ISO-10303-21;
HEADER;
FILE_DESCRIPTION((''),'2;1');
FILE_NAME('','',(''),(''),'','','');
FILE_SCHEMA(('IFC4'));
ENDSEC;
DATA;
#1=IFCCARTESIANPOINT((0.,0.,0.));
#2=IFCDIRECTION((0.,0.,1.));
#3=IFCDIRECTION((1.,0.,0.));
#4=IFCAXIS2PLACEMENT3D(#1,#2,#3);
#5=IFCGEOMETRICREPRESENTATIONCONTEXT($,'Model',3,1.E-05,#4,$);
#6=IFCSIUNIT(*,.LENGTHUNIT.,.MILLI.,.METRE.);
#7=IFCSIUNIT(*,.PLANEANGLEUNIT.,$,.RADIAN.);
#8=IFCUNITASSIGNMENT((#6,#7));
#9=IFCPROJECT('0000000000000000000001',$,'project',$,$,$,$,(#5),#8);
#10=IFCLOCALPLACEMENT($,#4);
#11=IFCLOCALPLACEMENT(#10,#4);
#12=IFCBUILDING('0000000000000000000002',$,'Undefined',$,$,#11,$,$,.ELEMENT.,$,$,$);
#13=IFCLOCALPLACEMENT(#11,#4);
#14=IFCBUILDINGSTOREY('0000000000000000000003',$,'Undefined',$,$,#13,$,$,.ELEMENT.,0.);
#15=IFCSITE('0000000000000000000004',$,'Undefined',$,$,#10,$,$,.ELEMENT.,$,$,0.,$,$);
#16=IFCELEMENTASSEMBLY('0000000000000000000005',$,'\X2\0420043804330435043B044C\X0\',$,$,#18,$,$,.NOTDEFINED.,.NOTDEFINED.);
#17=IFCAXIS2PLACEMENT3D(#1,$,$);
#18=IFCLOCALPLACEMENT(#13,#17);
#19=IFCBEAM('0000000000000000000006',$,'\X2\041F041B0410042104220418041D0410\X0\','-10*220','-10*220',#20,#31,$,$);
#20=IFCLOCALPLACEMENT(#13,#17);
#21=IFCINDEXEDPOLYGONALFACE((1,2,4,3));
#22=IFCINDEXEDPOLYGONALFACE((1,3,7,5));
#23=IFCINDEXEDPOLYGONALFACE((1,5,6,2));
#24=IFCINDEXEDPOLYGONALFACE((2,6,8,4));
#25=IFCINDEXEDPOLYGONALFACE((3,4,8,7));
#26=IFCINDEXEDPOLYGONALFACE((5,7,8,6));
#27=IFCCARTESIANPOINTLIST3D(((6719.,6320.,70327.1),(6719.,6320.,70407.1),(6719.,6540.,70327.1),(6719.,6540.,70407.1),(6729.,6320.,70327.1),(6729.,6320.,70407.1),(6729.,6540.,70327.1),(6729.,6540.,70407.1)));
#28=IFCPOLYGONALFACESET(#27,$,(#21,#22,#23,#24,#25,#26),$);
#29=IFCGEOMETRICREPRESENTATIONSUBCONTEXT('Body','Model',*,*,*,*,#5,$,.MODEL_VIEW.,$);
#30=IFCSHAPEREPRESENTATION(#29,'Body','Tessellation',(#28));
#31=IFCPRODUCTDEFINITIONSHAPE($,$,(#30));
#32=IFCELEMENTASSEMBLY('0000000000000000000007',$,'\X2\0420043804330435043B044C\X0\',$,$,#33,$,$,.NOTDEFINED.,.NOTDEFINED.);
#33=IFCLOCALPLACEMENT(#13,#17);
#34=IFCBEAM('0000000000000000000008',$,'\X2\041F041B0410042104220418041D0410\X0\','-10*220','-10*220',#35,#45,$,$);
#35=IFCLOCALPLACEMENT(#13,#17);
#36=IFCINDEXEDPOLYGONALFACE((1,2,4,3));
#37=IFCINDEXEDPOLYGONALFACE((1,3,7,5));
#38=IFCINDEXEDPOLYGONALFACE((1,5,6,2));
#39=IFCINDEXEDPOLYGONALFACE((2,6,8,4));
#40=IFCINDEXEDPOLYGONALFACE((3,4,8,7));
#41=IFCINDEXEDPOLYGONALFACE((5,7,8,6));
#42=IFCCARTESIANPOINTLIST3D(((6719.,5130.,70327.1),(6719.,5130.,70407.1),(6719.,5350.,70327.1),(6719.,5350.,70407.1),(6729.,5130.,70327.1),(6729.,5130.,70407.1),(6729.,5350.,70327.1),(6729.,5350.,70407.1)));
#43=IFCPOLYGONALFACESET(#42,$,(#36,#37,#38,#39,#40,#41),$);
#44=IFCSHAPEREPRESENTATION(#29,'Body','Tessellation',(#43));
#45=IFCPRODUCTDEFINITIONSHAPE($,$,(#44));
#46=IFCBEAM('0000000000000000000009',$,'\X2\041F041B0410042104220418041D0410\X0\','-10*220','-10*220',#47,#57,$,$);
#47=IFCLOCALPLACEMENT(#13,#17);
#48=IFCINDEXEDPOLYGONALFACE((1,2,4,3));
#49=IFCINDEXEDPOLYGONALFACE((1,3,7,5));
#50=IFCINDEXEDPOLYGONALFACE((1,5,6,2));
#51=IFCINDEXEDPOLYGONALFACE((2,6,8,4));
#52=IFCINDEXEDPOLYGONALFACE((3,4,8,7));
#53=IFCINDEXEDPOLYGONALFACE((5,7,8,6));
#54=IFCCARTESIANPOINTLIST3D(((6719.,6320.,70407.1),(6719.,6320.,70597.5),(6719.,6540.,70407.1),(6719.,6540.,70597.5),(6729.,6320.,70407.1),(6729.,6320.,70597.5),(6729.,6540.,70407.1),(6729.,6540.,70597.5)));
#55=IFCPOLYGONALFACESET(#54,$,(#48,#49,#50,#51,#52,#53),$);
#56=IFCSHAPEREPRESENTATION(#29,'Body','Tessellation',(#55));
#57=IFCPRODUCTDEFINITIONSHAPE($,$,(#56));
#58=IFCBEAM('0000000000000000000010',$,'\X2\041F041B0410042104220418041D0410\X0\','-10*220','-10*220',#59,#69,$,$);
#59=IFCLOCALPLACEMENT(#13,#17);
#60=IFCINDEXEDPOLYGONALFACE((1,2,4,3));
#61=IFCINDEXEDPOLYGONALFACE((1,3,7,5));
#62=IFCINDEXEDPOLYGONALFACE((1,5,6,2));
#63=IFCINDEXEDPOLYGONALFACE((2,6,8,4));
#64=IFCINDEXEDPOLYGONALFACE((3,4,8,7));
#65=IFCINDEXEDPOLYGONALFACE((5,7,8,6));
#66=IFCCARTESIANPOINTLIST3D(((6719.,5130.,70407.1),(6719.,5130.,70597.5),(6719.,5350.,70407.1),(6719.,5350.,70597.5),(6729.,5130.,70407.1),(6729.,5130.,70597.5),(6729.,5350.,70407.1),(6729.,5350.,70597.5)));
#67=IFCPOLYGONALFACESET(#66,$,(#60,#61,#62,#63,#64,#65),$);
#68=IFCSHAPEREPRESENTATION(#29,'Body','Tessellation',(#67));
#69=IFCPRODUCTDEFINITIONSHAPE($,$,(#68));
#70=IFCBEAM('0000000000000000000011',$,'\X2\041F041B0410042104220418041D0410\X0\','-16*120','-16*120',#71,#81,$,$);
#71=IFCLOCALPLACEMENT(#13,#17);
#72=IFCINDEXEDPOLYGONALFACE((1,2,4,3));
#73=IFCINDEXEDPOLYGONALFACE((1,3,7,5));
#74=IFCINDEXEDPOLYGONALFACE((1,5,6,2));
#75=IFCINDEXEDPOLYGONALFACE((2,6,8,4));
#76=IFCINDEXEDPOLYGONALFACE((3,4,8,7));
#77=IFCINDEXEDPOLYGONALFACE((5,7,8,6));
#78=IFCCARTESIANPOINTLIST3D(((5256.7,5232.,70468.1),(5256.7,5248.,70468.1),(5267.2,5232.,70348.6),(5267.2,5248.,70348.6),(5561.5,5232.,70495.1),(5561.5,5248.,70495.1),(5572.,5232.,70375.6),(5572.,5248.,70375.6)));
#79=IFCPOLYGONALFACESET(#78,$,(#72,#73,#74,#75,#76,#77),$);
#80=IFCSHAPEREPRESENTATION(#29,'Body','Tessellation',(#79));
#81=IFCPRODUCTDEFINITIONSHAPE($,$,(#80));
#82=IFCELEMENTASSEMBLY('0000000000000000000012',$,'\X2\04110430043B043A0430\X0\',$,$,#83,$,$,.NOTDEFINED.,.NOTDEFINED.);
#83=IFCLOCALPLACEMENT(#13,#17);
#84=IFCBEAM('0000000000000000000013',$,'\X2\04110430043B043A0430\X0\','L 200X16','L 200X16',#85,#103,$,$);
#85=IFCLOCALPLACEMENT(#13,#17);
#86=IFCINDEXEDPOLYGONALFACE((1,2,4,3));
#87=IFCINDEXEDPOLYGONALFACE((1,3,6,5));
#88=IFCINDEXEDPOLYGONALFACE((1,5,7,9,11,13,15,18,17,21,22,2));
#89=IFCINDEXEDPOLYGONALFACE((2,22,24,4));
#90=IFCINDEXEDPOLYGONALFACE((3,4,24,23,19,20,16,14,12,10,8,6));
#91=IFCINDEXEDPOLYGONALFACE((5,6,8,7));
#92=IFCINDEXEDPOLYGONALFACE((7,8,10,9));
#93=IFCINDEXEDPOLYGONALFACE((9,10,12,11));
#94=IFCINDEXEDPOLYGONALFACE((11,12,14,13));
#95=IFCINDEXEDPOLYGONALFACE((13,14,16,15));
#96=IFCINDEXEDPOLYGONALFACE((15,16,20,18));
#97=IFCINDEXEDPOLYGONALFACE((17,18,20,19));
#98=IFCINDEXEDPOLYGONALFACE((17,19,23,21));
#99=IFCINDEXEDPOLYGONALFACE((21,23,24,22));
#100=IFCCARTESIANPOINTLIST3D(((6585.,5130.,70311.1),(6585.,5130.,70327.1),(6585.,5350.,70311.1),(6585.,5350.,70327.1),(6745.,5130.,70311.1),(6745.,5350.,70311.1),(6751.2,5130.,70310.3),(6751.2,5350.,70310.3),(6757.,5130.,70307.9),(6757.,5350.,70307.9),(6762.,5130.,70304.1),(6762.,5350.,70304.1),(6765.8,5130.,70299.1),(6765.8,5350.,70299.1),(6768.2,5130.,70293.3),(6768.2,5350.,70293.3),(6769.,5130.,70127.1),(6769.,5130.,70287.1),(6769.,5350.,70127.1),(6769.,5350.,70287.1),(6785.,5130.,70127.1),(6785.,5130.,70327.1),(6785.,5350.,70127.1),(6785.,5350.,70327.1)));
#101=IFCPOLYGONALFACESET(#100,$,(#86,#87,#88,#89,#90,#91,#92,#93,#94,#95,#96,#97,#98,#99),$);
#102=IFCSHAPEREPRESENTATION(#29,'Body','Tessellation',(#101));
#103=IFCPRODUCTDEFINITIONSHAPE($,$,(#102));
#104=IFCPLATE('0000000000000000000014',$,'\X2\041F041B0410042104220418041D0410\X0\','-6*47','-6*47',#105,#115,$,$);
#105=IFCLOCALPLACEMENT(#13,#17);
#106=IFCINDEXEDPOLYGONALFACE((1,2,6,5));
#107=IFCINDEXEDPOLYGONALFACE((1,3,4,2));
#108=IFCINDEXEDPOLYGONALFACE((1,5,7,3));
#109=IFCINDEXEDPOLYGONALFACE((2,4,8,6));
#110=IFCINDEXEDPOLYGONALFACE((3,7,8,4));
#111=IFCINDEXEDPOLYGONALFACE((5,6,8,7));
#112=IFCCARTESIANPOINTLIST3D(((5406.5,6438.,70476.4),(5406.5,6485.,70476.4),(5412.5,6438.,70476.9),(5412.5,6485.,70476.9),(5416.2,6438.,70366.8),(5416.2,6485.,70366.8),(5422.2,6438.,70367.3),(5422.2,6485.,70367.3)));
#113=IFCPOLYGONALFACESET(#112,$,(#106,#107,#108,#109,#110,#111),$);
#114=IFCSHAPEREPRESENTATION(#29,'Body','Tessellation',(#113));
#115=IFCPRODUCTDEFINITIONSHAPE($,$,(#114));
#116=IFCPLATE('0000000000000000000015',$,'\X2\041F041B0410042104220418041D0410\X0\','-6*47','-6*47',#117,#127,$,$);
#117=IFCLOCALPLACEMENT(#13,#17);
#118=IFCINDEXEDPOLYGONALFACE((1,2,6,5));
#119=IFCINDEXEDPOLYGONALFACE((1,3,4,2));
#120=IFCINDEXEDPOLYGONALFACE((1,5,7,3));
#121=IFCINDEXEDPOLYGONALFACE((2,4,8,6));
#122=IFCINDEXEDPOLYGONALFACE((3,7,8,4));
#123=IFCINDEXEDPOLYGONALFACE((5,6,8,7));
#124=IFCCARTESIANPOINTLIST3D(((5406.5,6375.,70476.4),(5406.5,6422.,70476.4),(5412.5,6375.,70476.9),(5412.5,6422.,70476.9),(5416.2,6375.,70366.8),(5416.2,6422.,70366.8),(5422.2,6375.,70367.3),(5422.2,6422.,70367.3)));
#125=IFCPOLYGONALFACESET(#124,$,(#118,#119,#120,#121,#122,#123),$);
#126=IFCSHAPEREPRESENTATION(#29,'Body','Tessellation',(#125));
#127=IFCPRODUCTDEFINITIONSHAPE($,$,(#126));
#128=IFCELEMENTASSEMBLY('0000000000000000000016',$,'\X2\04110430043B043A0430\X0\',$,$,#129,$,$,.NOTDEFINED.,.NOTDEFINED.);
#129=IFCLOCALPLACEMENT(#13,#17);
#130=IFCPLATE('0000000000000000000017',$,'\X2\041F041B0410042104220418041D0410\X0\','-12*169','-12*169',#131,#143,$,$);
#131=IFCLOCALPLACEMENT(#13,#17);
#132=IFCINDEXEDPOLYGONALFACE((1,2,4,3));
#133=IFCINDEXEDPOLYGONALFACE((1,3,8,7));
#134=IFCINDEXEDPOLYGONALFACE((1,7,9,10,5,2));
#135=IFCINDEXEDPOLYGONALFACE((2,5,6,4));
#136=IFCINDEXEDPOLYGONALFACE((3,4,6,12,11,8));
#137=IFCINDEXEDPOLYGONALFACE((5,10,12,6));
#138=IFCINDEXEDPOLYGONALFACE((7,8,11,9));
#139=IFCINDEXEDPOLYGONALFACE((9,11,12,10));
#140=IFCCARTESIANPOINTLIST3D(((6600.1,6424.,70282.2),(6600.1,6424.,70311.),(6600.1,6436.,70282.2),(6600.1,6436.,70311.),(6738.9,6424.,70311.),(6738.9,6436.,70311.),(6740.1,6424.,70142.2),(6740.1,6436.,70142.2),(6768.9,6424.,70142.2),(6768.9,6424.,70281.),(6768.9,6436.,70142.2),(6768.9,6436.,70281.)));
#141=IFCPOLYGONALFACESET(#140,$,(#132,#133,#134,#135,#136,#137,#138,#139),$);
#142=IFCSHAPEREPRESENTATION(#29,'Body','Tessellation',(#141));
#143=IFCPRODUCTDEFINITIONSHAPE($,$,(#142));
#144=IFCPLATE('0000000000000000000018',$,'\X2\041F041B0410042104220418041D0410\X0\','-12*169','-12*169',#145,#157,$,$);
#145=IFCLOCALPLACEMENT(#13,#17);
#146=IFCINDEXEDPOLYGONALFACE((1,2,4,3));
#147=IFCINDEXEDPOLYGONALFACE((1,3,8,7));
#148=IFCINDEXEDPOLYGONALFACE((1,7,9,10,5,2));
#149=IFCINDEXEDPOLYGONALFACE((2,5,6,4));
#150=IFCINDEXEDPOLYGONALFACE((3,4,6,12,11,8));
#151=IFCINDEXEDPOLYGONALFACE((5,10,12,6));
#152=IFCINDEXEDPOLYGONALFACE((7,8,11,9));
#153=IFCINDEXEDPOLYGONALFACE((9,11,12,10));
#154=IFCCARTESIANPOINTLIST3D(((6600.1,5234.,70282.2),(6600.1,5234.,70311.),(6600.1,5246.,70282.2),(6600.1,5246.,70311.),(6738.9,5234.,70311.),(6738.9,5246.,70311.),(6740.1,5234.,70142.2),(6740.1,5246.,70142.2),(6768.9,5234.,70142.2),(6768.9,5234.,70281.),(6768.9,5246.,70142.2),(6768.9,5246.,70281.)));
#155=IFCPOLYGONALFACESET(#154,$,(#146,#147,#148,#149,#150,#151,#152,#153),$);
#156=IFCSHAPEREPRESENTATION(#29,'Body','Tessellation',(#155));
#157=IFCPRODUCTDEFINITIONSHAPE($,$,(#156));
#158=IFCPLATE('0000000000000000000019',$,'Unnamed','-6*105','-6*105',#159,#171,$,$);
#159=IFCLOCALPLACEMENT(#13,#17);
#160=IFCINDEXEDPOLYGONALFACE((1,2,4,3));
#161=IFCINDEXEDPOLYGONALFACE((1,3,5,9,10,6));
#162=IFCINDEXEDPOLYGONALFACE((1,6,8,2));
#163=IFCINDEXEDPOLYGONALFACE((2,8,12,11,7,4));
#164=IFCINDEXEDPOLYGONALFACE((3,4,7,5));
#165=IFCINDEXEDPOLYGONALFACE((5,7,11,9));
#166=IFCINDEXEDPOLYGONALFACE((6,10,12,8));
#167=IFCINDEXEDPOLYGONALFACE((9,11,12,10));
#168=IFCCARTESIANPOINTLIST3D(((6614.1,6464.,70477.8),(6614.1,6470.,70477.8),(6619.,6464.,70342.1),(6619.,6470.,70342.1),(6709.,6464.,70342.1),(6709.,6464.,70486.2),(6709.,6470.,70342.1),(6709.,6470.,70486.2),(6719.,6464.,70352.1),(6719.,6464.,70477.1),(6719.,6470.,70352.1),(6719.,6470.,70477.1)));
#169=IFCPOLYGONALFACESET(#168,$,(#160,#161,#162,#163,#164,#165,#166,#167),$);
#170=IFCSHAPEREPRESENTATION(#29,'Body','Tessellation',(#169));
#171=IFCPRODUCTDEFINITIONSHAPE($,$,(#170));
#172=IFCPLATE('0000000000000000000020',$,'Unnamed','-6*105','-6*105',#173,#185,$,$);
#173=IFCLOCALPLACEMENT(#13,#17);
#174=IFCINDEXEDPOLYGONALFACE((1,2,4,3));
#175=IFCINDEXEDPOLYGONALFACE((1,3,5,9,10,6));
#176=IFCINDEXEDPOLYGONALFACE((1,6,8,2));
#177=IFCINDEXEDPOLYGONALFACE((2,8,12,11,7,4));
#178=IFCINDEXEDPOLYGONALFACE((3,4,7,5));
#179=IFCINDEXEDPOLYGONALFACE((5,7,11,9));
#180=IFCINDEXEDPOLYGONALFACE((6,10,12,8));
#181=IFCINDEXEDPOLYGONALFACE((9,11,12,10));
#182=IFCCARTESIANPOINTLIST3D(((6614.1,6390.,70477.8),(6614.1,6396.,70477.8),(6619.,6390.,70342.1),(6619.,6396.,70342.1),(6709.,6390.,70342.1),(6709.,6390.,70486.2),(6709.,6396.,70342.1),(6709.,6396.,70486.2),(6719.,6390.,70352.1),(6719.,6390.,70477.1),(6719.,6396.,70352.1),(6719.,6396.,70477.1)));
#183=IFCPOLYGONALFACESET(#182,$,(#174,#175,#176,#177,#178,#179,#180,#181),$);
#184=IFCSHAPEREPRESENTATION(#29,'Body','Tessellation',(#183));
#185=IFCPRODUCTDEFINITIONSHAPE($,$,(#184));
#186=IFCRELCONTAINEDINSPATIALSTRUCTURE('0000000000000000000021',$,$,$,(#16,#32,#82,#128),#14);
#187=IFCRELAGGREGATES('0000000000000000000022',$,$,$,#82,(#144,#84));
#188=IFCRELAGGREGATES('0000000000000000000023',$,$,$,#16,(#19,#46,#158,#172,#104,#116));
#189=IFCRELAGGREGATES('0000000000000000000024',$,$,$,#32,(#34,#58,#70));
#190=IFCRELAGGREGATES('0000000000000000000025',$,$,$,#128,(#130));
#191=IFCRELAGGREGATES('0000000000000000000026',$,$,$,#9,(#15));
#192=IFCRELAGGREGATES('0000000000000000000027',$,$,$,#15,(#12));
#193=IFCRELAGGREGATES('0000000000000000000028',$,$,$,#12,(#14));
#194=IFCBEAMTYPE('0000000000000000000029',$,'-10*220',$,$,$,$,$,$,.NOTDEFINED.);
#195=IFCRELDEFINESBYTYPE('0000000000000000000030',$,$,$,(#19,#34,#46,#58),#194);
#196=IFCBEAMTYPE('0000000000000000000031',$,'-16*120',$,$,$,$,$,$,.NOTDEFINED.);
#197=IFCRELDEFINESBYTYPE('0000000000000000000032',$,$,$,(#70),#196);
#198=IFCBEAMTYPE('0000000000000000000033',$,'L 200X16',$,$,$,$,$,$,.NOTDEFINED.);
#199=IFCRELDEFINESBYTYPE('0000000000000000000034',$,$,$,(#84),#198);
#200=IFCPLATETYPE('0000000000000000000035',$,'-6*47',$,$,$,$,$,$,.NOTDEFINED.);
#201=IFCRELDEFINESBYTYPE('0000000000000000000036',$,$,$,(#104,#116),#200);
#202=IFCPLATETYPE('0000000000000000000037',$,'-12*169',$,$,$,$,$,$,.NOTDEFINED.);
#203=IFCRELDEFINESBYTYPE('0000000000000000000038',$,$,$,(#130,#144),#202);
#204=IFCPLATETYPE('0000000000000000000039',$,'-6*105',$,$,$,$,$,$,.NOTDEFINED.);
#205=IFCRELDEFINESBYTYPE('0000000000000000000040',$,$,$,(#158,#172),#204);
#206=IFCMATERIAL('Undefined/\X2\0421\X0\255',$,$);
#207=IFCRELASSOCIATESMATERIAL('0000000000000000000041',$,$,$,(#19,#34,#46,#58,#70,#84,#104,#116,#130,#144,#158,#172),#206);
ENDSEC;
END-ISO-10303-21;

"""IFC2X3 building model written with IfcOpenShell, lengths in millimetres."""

from ifc_helpers import new_model, si_unit, frame, origin_with_axes, origin_2d_with_axis, place, context, subcontext, project, spatial, polyline, rectangle, l_section, outline, extrude, boolean, material, type_object, element, aggregate, save


model = new_model("IFC2X3")

# Units and contexts
model_context = context("Model", 3, precision=1e-05, world=origin_with_axes())
body_context = subcontext(model_context, "Body", "Model", "MODEL_VIEW")
ifc_project = project(units=[si_unit("LENGTHUNIT", "METRE", prefix="MILLI"), si_unit("PLANEANGLEUNIT", "RADIAN")], contexts=[model_context])

# Site, building, storey
site_placement = place(None, origin_with_axes())
site = spatial("IfcSite", under=ifc_project, at=site_placement, Name="Undefined", CompositionType="ELEMENT", RefElevation=0.0)
building_placement = place(site_placement, origin_with_axes())
building = spatial("IfcBuilding", under=site, at=building_placement, Name="Undefined", CompositionType="ELEMENT")
storey_placement = place(building_placement, origin_with_axes())
storey = spatial("IfcBuildingStorey", under=building, at=storey_placement, Name="Undefined", CompositionType="ELEMENT", Elevation=0.0)

# Element assemblies, beams
assembly_1_placement = place(storey_placement, origin_with_axes())
assembly_1 = element("IfcElementAssembly", 1, at=assembly_1_placement, inside=storey, Name="Ригель", AssemblyPlace="NOTDEFINED", PredefinedType="NOTDEFINED")
ifc_material_1 = material(Name="Undefined/С255")
beam_type_1 = type_object("IfcBeamType", Name="-10*220", PredefinedType="NOTDEFINED")
beam_1_placement = place(assembly_1_placement, frame((6724.0, 6430.0, 70327.1), z_axis=(0.0, 1.0, 0.0), x_axis=(0.0, 0.0, 1.0)))
beam_1 = element("IfcBeam", 2, at=beam_1_placement, type_object=beam_type_1, material=ifc_material_1, Name="ПЛАСТИНА", Description="-10*220", ObjectType="-10*220", context=body_context, shape_type="SweptSolid", body=[
    extrude(rectangle(XDim=10.0, YDim=220.0, at=origin_2d_with_axis()), frame((80.0, 0.0, 0.0), z_axis=(-1.0, 0.0, 0.0), x_axis=(0.0, -1.0, 0.0)), (0.0, 0.0, 1.0), 80.0),
])
assembly_2_placement = place(storey_placement, origin_with_axes())
assembly_2 = element("IfcElementAssembly", 3, at=assembly_2_placement, inside=storey, Name="Ригель", AssemblyPlace="NOTDEFINED", PredefinedType="NOTDEFINED")
beam_2_placement = place(assembly_2_placement, frame((6724.0, 5240.0, 70327.1), z_axis=(0.0, 1.0, 0.0), x_axis=(0.0, 0.0, 1.0)))
beam_2 = element("IfcBeam", 4, at=beam_2_placement, type_object=beam_type_1, material=ifc_material_1, Name="ПЛАСТИНА", Description="-10*220", ObjectType="-10*220", context=body_context, shape_type="SweptSolid", body=[
    extrude(rectangle(XDim=10.0, YDim=220.0, at=origin_2d_with_axis()), frame((80.0, 0.0, 0.0), z_axis=(-1.0, 0.0, 0.0), x_axis=(0.0, -1.0, 0.0)), (0.0, 0.0, 1.0), 80.0),
])

# Beams
beam_3_placement = place(assembly_1_placement, frame((6724.0, 6430.0, 70407.1), z_axis=(0.0, 1.0, 0.0), x_axis=(0.0, 0.0, 1.0)))
beam_3 = element("IfcBeam", 5, at=beam_3_placement, type_object=beam_type_1, material=ifc_material_1, Name="ПЛАСТИНА", Description="-10*220", ObjectType="-10*220", context=body_context, shape_type="SweptSolid", body=[
    extrude(rectangle(XDim=10.0, YDim=220.0, at=origin_2d_with_axis()), frame((190.4, 0.0, 0.0), z_axis=(-1.0, 0.0, 0.0), x_axis=(0.0, -1.0, 0.0)), (0.0, 0.0, 1.0), 190.4),
])
beam_4_placement = place(assembly_2_placement, frame((6724.0, 5240.0, 70407.1), z_axis=(0.0, 1.0, 0.0), x_axis=(0.0, 0.0, 1.0)))
beam_4 = element("IfcBeam", 6, at=beam_4_placement, type_object=beam_type_1, material=ifc_material_1, Name="ПЛАСТИНА", Description="-10*220", ObjectType="-10*220", context=body_context, shape_type="SweptSolid", body=[
    extrude(rectangle(XDim=10.0, YDim=220.0, at=origin_2d_with_axis()), frame((190.4, 0.0, 0.0), z_axis=(-1.0, 0.0, 0.0), x_axis=(0.0, -1.0, 0.0)), (0.0, 0.0, 1.0), 190.4),
])
beam_type_2 = type_object("IfcBeamType", Name="-16*120", PredefinedType="NOTDEFINED")
beam_5_placement = place(assembly_2_placement, frame((5261.9, 5240.0, 70408.4), z_axis=(0.088152, 0.0, -0.996107), x_axis=(0.996107, 0.0, 0.088152)))
beam_5 = element("IfcBeam", 7, at=beam_5_placement, type_object=beam_type_2, material=ifc_material_1, Name="ПЛАСТИНА", Description="-16*120", ObjectType="-16*120", context=body_context, shape_type="SweptSolid", body=[
    extrude(rectangle(XDim=16.0, YDim=120.0, at=origin_2d_with_axis()), frame((306.0, 0.0, 0.0), z_axis=(-1.0, 0.0, 0.0), x_axis=(0.0, -1.0, 0.0)), (0.0, 0.0, 1.0), 306.0),
])

# Element assembly, beam
assembly_3_placement = place(storey_placement, origin_with_axes())
assembly_3 = element("IfcElementAssembly", 8, at=assembly_3_placement, inside=storey, Name="Балка", AssemblyPlace="NOTDEFINED", PredefinedType="NOTDEFINED")
beam_type_3 = type_object("IfcBeamType", Name="L 200X16", PredefinedType="NOTDEFINED")
beam_6_placement = place(assembly_3_placement, frame((6685.0, 5350.0, 70227.1), z_axis=(-1.0, 0.0, 0.0), x_axis=(0.0, -1.0, 0.0)))
beam_6 = element("IfcBeam", 9, at=beam_6_placement, type_object=beam_type_3, material=ifc_material_1, Name="Балка", Description="L 200X16", ObjectType="L 200X16", context=body_context, shape_type="SweptSolid", body=[
    extrude(l_section(Depth=200.0, Width=200.0, Thickness=16.0, FilletRadius=24.0, at=origin_2d_with_axis()), frame((220.0, 0.0, 0.0), z_axis=(-1.0, 0.0, 0.0), x_axis=(0.0, -1.0, 0.0)), (0.0, 0.0, 1.0), 220.0),
])

# Plates
plate_type_1 = type_object("IfcPlateType", Name="-6*47", PredefinedType="NOTDEFINED")
plate_1_placement = place(assembly_1_placement, frame((5419.2, 6375.0, 70367.1), z_axis=(-0.996107, 0.0, -0.088152), x_axis=(-0.088152, 0.0, 0.996107)))
plate_1 = element("IfcPlate", 10, at=plate_1_placement, type_object=plate_type_1, material=ifc_material_1, Name="ПЛАСТИНА", Description="-6*47", ObjectType="-6*47", context=body_context, shape_type="CSG", body=[
    boolean("DIFFERENCE", extrude(outline(polyline([(0.0, 0.0), (110.0, 0.0), (110.0, 110.0), (0.0, 110.0), (0.0, 0.0)])), frame((0.0, 0.0, -3.0), z_axis=(0.0, 0.0, 1.0), x_axis=(1.0, 0.0, 0.0)), (0.0, 0.0, 1.0), 6.0), extrude(rectangle(XDim=26.0, YDim=130.0, at=origin_2d_with_axis()), frame((55.0, -3.0, 0.0), z_axis=(0.0, 1.0, 0.0), x_axis=(0.0, 0.0, -1.0)), (0.0, 0.0, 1.0), 66.0)),
])
plate_2_placement = place(assembly_1_placement, frame((5419.2, 6375.0, 70367.1), z_axis=(-0.996107, 0.0, -0.088152), x_axis=(-0.088152, 0.0, 0.996107)))
plate_2 = element("IfcPlate", 11, at=plate_2_placement, type_object=plate_type_1, material=ifc_material_1, Name="ПЛАСТИНА", Description="-6*47", ObjectType="-6*47", context=body_context, shape_type="CSG", body=[
    boolean("DIFFERENCE", extrude(outline(polyline([(0.0, 0.0), (110.0, 0.0), (110.0, 110.0), (0.0, 110.0), (0.0, 0.0)])), frame((0.0, 0.0, -3.0), z_axis=(0.0, 0.0, 1.0), x_axis=(1.0, 0.0, 0.0)), (0.0, 0.0, 1.0), 6.0), extrude(rectangle(XDim=26.0, YDim=130.0, at=origin_2d_with_axis()), frame((55.0, 47.0, 0.0), z_axis=(0.0, 1.0, 0.0), x_axis=(0.0, 0.0, -1.0)), (0.0, 0.0, 1.0), 66.0)),
])

# Element assembly, plate
assembly_4_placement = place(storey_placement, origin_with_axes())
assembly_4 = element("IfcElementAssembly", 12, at=assembly_4_placement, inside=storey, Name="Балка", AssemblyPlace="NOTDEFINED", PredefinedType="NOTDEFINED")
plate_type_2 = type_object("IfcPlateType", Name="-12*169", PredefinedType="NOTDEFINED")
plate_3_placement = place(assembly_4_placement, frame((6600.1, 6430.0, 70142.2), z_axis=(0.0, 1.0, 0.0), x_axis=(0.0, 0.0, 1.0)))
plate_3 = element("IfcPlate", 13, at=plate_3_placement, type_object=plate_type_2, material=ifc_material_1, Name="ПЛАСТИНА", Description="-12*169", ObjectType="-12*169", context=body_context, shape_type="SweptSolid", body=[
    extrude(outline(polyline([(0.0, 140.0), (140.0, 0.0), (168.8, 0.0), (168.8, 138.8), (138.8, 168.8), (0.0, 168.8), (0.0, 140.0)])), frame((0.0, 0.0, -6.0), z_axis=(0.0, 0.0, 1.0), x_axis=(1.0, 0.0, 0.0)), (0.0, 0.0, 1.0), 12.0),
])

# Plates
plate_4_placement = place(assembly_3_placement, frame((6600.1, 5240.0, 70142.2), z_axis=(0.0, 1.0, 0.0), x_axis=(0.0, 0.0, 1.0)))
plate_4 = element("IfcPlate", 14, at=plate_4_placement, type_object=plate_type_2, material=ifc_material_1, Name="ПЛАСТИНА", Description="-12*169", ObjectType="-12*169", context=body_context, shape_type="SweptSolid", body=[
    extrude(outline(polyline([(0.0, 140.0), (140.0, 0.0), (168.8, 0.0), (168.8, 138.8), (138.8, 168.8), (0.0, 168.8), (0.0, 140.0)])), frame((0.0, 0.0, -6.0), z_axis=(0.0, 0.0, 1.0), x_axis=(1.0, 0.0, 0.0)), (0.0, 0.0, 1.0), 12.0),
])
aggregate(assembly_3, [plate_4, beam_6])
plate_type_3 = type_object("IfcPlateType", Name="-6*105", PredefinedType="NOTDEFINED")
plate_5_placement = place(assembly_1_placement, frame((6719.0, 6467.0, 70342.1), z_axis=(0.0, -1.0, 0.0), x_axis=(0.0, 0.0, 1.0)))
plate_5 = element("IfcPlate", 15, at=plate_5_placement, type_object=plate_type_3, material=ifc_material_1, Name="Unnamed", Description="-6*105", ObjectType="-6*105", context=body_context, shape_type="SweptSolid", body=[
    extrude(outline(polyline([(0.0, 10.0), (10.0, 0.0), (135.0, 0.0), (144.1, 10.0), (135.7, 104.9), (0.0, 100.0), (0.0, 10.0)])), frame((0.0, 0.0, -3.0), z_axis=(0.0, 0.0, 1.0), x_axis=(1.0, 0.0, 0.0)), (0.0, 0.0, 1.0), 6.0),
])
plate_6_placement = place(assembly_1_placement, frame((6719.0, 6393.0, 70342.1), z_axis=(0.0, -1.0, 0.0), x_axis=(0.0, 0.0, 1.0)))
plate_6 = element("IfcPlate", 16, at=plate_6_placement, type_object=plate_type_3, material=ifc_material_1, Name="Unnamed", Description="-6*105", ObjectType="-6*105", context=body_context, shape_type="SweptSolid", body=[
    extrude(outline(polyline([(0.0, 10.0), (10.0, 0.0), (135.0, 0.0), (144.1, 10.0), (135.7, 104.9), (0.0, 100.0), (0.0, 10.0)])), frame((0.0, 0.0, -3.0), z_axis=(0.0, 0.0, 1.0), x_axis=(1.0, 0.0, 0.0)), (0.0, 0.0, 1.0), 6.0),
])

aggregate(assembly_1, [beam_1, beam_3, plate_5, plate_6, plate_1, plate_2])
aggregate(assembly_2, [beam_2, beam_4, beam_5])

aggregate(assembly_4, [plate_3])

save(model, "model.ifc")
